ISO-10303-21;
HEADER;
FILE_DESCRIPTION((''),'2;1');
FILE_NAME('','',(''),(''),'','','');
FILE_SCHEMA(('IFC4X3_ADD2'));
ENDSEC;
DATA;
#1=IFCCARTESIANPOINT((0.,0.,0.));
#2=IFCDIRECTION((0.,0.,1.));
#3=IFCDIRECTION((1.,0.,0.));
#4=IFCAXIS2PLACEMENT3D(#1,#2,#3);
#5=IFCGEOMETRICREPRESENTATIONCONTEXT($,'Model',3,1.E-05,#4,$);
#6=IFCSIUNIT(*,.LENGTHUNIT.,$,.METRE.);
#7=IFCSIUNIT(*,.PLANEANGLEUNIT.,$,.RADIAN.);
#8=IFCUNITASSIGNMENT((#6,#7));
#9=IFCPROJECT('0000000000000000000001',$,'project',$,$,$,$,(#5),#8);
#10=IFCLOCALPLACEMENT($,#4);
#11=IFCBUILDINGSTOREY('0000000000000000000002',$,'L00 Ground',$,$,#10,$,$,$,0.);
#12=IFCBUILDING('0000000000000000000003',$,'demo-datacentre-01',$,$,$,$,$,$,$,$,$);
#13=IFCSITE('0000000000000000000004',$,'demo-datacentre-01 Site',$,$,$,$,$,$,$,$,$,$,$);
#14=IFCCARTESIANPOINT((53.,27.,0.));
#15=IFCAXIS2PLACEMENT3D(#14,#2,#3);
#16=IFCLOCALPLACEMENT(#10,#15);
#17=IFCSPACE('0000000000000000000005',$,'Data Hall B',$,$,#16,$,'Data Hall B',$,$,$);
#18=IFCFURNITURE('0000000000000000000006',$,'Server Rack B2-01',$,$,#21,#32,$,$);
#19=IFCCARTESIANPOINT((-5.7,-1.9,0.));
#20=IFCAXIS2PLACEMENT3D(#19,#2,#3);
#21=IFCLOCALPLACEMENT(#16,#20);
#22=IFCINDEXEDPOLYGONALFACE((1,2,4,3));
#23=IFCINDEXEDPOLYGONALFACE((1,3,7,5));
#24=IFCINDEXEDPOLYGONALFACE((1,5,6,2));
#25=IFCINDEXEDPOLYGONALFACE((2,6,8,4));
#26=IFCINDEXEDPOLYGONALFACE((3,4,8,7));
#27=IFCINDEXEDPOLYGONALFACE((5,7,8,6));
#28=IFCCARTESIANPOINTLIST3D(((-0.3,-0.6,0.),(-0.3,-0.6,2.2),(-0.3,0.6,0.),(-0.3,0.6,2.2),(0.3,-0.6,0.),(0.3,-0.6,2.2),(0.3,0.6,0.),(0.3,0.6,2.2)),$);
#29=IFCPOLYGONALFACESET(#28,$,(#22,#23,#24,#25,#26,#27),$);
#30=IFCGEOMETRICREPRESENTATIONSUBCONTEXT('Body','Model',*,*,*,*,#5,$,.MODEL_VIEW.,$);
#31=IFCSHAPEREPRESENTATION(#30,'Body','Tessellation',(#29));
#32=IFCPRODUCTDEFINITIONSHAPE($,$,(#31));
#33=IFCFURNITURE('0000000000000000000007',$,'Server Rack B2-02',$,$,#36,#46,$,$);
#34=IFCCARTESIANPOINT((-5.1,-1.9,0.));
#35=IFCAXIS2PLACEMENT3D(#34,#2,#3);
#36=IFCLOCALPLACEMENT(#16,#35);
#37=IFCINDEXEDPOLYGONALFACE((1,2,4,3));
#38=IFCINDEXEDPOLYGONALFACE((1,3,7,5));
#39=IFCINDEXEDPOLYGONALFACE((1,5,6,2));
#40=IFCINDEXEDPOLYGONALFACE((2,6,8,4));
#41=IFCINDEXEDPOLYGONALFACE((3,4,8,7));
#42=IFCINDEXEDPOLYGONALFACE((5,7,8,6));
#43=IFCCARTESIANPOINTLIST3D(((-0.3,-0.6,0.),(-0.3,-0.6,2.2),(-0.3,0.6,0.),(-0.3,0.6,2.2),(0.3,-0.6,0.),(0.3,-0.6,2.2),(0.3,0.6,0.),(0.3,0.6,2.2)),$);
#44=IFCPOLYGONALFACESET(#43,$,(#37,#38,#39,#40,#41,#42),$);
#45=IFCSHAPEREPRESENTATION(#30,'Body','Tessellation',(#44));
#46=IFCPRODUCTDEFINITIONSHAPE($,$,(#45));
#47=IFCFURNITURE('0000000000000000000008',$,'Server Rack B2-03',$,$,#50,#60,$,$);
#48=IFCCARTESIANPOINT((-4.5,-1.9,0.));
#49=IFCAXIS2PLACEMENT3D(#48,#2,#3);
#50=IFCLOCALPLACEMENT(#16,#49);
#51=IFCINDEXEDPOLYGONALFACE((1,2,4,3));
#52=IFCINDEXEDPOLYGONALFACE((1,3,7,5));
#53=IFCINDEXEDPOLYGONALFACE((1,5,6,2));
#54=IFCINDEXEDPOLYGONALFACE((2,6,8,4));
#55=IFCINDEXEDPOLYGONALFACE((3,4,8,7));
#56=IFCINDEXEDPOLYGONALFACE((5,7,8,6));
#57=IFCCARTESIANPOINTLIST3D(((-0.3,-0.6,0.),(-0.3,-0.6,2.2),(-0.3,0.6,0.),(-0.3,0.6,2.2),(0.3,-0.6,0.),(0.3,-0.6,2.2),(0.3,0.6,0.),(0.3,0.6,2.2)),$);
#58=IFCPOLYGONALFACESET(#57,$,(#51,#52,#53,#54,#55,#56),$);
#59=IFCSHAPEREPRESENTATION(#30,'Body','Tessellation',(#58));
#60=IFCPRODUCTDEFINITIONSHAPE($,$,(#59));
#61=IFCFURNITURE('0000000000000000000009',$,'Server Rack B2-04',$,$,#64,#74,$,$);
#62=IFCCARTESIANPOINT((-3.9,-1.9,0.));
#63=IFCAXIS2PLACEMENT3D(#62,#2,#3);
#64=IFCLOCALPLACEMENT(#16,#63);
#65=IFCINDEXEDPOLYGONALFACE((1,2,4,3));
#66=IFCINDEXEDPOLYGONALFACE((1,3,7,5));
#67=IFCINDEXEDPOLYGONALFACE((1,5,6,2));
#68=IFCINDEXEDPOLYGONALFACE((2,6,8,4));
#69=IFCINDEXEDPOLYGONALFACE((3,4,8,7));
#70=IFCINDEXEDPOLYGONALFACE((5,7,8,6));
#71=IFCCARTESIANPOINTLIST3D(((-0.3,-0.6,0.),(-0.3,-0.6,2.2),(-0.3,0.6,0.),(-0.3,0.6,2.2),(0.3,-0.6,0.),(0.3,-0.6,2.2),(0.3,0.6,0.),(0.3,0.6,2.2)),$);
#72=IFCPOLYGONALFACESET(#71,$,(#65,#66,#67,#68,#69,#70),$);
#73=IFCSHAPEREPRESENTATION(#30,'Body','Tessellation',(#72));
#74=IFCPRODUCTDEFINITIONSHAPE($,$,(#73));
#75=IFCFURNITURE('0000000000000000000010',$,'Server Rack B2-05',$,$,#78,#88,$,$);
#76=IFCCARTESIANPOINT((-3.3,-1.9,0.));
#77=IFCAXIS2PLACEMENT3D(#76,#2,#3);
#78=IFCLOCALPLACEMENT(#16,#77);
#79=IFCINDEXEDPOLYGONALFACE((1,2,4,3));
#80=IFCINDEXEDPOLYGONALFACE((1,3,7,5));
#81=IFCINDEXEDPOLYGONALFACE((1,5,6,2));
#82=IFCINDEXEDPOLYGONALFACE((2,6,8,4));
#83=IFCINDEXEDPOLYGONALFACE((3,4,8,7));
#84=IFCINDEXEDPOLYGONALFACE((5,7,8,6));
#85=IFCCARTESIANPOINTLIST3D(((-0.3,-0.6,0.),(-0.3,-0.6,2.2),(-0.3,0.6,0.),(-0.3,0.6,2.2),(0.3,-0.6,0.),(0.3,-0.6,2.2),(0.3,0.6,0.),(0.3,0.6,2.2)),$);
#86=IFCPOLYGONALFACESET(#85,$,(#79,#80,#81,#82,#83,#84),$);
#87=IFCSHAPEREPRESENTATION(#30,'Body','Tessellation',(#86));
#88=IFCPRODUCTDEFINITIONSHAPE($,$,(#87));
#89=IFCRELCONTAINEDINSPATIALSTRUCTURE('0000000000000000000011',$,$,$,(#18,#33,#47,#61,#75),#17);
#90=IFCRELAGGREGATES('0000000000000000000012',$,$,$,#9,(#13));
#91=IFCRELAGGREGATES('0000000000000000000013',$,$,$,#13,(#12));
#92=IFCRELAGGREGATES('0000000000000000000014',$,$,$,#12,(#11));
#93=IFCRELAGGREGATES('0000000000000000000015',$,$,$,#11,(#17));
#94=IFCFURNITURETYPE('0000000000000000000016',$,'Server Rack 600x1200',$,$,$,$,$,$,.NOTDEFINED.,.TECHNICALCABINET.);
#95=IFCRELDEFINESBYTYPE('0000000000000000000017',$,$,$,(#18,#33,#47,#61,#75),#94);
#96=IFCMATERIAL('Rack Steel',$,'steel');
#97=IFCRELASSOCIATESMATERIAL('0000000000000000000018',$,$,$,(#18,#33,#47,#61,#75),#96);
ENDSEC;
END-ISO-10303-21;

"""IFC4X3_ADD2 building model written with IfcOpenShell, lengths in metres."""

from ifc_helpers import new_model, si_unit, frame, origin_with_axes, place, context, subcontext, project, spatial, rectangle, extrude, material, type_object, element, save


model = new_model("IFC4X3_ADD2")

# Units and contexts
model_context = context("Model", 3, precision=1e-05, world=origin_with_axes())
body_context = subcontext(model_context, "Body", "Model", "MODEL_VIEW")
ifc_project = project(units=[si_unit("LENGTHUNIT", "METRE"), si_unit("PLANEANGLEUNIT", "RADIAN")], contexts=[model_context])

# Site, building, storey
site = spatial("IfcSite", under=ifc_project, Name="demo-datacentre-01 Site")
building = spatial("IfcBuilding", under=site, Name="demo-datacentre-01")
storey_placement = place(None, origin_with_axes())
storey = spatial("IfcBuildingStorey", under=building, at=storey_placement, Name="L00 Ground", Elevation=0.0)

# Shared definitions
space_placement = place(storey_placement, frame((53.0, 27.0, 0.0), z_axis=(0.0, 0.0, 1.0), x_axis=(1.0, 0.0, 0.0)))
space = spatial("IfcSpace", under=storey, at=space_placement, Name="Data Hall B", LongName="Data Hall B")

# Furniture
ifc_material_1 = material(Name="Rack Steel", Category="steel")
furniture_type = type_object("IfcFurnitureType", Name="Server Rack 600x1200", AssemblyPlace="NOTDEFINED", PredefinedType="TECHNICALCABINET")
for number, where, z_axis, x_axis, name in (
    (1, (-5.7, -1.9, 0.0), (0.0, 0.0, 1.0), (1.0, 0.0, 0.0), "Server Rack B2-01"),
    (2, (-5.1, -1.9, 0.0), (0.0, 0.0, 1.0), (1.0, 0.0, 0.0), "Server Rack B2-02"),
    (3, (-4.5, -1.9, 0.0), (0.0, 0.0, 1.0), (1.0, 0.0, 0.0), "Server Rack B2-03"),
    (4, (-3.9, -1.9, 0.0), (0.0, 0.0, 1.0), (1.0, 0.0, 0.0), "Server Rack B2-04"),
    (5, (-3.3, -1.9, 0.0), (0.0, 0.0, 1.0), (1.0, 0.0, 0.0), "Server Rack B2-05"),
):
    element("IfcFurniture", number, at=place(space_placement, frame(where, z_axis=z_axis, x_axis=x_axis)), inside=space, type_object=furniture_type, material=ifc_material_1, Name=name, context=body_context, shape_type="SweptSolid", body=[
        extrude(rectangle(XDim=0.6, YDim=1.2), origin_with_axes(), (0.0, 0.0, 1.0), 2.2),
    ])

save(model, "model.ifc")
